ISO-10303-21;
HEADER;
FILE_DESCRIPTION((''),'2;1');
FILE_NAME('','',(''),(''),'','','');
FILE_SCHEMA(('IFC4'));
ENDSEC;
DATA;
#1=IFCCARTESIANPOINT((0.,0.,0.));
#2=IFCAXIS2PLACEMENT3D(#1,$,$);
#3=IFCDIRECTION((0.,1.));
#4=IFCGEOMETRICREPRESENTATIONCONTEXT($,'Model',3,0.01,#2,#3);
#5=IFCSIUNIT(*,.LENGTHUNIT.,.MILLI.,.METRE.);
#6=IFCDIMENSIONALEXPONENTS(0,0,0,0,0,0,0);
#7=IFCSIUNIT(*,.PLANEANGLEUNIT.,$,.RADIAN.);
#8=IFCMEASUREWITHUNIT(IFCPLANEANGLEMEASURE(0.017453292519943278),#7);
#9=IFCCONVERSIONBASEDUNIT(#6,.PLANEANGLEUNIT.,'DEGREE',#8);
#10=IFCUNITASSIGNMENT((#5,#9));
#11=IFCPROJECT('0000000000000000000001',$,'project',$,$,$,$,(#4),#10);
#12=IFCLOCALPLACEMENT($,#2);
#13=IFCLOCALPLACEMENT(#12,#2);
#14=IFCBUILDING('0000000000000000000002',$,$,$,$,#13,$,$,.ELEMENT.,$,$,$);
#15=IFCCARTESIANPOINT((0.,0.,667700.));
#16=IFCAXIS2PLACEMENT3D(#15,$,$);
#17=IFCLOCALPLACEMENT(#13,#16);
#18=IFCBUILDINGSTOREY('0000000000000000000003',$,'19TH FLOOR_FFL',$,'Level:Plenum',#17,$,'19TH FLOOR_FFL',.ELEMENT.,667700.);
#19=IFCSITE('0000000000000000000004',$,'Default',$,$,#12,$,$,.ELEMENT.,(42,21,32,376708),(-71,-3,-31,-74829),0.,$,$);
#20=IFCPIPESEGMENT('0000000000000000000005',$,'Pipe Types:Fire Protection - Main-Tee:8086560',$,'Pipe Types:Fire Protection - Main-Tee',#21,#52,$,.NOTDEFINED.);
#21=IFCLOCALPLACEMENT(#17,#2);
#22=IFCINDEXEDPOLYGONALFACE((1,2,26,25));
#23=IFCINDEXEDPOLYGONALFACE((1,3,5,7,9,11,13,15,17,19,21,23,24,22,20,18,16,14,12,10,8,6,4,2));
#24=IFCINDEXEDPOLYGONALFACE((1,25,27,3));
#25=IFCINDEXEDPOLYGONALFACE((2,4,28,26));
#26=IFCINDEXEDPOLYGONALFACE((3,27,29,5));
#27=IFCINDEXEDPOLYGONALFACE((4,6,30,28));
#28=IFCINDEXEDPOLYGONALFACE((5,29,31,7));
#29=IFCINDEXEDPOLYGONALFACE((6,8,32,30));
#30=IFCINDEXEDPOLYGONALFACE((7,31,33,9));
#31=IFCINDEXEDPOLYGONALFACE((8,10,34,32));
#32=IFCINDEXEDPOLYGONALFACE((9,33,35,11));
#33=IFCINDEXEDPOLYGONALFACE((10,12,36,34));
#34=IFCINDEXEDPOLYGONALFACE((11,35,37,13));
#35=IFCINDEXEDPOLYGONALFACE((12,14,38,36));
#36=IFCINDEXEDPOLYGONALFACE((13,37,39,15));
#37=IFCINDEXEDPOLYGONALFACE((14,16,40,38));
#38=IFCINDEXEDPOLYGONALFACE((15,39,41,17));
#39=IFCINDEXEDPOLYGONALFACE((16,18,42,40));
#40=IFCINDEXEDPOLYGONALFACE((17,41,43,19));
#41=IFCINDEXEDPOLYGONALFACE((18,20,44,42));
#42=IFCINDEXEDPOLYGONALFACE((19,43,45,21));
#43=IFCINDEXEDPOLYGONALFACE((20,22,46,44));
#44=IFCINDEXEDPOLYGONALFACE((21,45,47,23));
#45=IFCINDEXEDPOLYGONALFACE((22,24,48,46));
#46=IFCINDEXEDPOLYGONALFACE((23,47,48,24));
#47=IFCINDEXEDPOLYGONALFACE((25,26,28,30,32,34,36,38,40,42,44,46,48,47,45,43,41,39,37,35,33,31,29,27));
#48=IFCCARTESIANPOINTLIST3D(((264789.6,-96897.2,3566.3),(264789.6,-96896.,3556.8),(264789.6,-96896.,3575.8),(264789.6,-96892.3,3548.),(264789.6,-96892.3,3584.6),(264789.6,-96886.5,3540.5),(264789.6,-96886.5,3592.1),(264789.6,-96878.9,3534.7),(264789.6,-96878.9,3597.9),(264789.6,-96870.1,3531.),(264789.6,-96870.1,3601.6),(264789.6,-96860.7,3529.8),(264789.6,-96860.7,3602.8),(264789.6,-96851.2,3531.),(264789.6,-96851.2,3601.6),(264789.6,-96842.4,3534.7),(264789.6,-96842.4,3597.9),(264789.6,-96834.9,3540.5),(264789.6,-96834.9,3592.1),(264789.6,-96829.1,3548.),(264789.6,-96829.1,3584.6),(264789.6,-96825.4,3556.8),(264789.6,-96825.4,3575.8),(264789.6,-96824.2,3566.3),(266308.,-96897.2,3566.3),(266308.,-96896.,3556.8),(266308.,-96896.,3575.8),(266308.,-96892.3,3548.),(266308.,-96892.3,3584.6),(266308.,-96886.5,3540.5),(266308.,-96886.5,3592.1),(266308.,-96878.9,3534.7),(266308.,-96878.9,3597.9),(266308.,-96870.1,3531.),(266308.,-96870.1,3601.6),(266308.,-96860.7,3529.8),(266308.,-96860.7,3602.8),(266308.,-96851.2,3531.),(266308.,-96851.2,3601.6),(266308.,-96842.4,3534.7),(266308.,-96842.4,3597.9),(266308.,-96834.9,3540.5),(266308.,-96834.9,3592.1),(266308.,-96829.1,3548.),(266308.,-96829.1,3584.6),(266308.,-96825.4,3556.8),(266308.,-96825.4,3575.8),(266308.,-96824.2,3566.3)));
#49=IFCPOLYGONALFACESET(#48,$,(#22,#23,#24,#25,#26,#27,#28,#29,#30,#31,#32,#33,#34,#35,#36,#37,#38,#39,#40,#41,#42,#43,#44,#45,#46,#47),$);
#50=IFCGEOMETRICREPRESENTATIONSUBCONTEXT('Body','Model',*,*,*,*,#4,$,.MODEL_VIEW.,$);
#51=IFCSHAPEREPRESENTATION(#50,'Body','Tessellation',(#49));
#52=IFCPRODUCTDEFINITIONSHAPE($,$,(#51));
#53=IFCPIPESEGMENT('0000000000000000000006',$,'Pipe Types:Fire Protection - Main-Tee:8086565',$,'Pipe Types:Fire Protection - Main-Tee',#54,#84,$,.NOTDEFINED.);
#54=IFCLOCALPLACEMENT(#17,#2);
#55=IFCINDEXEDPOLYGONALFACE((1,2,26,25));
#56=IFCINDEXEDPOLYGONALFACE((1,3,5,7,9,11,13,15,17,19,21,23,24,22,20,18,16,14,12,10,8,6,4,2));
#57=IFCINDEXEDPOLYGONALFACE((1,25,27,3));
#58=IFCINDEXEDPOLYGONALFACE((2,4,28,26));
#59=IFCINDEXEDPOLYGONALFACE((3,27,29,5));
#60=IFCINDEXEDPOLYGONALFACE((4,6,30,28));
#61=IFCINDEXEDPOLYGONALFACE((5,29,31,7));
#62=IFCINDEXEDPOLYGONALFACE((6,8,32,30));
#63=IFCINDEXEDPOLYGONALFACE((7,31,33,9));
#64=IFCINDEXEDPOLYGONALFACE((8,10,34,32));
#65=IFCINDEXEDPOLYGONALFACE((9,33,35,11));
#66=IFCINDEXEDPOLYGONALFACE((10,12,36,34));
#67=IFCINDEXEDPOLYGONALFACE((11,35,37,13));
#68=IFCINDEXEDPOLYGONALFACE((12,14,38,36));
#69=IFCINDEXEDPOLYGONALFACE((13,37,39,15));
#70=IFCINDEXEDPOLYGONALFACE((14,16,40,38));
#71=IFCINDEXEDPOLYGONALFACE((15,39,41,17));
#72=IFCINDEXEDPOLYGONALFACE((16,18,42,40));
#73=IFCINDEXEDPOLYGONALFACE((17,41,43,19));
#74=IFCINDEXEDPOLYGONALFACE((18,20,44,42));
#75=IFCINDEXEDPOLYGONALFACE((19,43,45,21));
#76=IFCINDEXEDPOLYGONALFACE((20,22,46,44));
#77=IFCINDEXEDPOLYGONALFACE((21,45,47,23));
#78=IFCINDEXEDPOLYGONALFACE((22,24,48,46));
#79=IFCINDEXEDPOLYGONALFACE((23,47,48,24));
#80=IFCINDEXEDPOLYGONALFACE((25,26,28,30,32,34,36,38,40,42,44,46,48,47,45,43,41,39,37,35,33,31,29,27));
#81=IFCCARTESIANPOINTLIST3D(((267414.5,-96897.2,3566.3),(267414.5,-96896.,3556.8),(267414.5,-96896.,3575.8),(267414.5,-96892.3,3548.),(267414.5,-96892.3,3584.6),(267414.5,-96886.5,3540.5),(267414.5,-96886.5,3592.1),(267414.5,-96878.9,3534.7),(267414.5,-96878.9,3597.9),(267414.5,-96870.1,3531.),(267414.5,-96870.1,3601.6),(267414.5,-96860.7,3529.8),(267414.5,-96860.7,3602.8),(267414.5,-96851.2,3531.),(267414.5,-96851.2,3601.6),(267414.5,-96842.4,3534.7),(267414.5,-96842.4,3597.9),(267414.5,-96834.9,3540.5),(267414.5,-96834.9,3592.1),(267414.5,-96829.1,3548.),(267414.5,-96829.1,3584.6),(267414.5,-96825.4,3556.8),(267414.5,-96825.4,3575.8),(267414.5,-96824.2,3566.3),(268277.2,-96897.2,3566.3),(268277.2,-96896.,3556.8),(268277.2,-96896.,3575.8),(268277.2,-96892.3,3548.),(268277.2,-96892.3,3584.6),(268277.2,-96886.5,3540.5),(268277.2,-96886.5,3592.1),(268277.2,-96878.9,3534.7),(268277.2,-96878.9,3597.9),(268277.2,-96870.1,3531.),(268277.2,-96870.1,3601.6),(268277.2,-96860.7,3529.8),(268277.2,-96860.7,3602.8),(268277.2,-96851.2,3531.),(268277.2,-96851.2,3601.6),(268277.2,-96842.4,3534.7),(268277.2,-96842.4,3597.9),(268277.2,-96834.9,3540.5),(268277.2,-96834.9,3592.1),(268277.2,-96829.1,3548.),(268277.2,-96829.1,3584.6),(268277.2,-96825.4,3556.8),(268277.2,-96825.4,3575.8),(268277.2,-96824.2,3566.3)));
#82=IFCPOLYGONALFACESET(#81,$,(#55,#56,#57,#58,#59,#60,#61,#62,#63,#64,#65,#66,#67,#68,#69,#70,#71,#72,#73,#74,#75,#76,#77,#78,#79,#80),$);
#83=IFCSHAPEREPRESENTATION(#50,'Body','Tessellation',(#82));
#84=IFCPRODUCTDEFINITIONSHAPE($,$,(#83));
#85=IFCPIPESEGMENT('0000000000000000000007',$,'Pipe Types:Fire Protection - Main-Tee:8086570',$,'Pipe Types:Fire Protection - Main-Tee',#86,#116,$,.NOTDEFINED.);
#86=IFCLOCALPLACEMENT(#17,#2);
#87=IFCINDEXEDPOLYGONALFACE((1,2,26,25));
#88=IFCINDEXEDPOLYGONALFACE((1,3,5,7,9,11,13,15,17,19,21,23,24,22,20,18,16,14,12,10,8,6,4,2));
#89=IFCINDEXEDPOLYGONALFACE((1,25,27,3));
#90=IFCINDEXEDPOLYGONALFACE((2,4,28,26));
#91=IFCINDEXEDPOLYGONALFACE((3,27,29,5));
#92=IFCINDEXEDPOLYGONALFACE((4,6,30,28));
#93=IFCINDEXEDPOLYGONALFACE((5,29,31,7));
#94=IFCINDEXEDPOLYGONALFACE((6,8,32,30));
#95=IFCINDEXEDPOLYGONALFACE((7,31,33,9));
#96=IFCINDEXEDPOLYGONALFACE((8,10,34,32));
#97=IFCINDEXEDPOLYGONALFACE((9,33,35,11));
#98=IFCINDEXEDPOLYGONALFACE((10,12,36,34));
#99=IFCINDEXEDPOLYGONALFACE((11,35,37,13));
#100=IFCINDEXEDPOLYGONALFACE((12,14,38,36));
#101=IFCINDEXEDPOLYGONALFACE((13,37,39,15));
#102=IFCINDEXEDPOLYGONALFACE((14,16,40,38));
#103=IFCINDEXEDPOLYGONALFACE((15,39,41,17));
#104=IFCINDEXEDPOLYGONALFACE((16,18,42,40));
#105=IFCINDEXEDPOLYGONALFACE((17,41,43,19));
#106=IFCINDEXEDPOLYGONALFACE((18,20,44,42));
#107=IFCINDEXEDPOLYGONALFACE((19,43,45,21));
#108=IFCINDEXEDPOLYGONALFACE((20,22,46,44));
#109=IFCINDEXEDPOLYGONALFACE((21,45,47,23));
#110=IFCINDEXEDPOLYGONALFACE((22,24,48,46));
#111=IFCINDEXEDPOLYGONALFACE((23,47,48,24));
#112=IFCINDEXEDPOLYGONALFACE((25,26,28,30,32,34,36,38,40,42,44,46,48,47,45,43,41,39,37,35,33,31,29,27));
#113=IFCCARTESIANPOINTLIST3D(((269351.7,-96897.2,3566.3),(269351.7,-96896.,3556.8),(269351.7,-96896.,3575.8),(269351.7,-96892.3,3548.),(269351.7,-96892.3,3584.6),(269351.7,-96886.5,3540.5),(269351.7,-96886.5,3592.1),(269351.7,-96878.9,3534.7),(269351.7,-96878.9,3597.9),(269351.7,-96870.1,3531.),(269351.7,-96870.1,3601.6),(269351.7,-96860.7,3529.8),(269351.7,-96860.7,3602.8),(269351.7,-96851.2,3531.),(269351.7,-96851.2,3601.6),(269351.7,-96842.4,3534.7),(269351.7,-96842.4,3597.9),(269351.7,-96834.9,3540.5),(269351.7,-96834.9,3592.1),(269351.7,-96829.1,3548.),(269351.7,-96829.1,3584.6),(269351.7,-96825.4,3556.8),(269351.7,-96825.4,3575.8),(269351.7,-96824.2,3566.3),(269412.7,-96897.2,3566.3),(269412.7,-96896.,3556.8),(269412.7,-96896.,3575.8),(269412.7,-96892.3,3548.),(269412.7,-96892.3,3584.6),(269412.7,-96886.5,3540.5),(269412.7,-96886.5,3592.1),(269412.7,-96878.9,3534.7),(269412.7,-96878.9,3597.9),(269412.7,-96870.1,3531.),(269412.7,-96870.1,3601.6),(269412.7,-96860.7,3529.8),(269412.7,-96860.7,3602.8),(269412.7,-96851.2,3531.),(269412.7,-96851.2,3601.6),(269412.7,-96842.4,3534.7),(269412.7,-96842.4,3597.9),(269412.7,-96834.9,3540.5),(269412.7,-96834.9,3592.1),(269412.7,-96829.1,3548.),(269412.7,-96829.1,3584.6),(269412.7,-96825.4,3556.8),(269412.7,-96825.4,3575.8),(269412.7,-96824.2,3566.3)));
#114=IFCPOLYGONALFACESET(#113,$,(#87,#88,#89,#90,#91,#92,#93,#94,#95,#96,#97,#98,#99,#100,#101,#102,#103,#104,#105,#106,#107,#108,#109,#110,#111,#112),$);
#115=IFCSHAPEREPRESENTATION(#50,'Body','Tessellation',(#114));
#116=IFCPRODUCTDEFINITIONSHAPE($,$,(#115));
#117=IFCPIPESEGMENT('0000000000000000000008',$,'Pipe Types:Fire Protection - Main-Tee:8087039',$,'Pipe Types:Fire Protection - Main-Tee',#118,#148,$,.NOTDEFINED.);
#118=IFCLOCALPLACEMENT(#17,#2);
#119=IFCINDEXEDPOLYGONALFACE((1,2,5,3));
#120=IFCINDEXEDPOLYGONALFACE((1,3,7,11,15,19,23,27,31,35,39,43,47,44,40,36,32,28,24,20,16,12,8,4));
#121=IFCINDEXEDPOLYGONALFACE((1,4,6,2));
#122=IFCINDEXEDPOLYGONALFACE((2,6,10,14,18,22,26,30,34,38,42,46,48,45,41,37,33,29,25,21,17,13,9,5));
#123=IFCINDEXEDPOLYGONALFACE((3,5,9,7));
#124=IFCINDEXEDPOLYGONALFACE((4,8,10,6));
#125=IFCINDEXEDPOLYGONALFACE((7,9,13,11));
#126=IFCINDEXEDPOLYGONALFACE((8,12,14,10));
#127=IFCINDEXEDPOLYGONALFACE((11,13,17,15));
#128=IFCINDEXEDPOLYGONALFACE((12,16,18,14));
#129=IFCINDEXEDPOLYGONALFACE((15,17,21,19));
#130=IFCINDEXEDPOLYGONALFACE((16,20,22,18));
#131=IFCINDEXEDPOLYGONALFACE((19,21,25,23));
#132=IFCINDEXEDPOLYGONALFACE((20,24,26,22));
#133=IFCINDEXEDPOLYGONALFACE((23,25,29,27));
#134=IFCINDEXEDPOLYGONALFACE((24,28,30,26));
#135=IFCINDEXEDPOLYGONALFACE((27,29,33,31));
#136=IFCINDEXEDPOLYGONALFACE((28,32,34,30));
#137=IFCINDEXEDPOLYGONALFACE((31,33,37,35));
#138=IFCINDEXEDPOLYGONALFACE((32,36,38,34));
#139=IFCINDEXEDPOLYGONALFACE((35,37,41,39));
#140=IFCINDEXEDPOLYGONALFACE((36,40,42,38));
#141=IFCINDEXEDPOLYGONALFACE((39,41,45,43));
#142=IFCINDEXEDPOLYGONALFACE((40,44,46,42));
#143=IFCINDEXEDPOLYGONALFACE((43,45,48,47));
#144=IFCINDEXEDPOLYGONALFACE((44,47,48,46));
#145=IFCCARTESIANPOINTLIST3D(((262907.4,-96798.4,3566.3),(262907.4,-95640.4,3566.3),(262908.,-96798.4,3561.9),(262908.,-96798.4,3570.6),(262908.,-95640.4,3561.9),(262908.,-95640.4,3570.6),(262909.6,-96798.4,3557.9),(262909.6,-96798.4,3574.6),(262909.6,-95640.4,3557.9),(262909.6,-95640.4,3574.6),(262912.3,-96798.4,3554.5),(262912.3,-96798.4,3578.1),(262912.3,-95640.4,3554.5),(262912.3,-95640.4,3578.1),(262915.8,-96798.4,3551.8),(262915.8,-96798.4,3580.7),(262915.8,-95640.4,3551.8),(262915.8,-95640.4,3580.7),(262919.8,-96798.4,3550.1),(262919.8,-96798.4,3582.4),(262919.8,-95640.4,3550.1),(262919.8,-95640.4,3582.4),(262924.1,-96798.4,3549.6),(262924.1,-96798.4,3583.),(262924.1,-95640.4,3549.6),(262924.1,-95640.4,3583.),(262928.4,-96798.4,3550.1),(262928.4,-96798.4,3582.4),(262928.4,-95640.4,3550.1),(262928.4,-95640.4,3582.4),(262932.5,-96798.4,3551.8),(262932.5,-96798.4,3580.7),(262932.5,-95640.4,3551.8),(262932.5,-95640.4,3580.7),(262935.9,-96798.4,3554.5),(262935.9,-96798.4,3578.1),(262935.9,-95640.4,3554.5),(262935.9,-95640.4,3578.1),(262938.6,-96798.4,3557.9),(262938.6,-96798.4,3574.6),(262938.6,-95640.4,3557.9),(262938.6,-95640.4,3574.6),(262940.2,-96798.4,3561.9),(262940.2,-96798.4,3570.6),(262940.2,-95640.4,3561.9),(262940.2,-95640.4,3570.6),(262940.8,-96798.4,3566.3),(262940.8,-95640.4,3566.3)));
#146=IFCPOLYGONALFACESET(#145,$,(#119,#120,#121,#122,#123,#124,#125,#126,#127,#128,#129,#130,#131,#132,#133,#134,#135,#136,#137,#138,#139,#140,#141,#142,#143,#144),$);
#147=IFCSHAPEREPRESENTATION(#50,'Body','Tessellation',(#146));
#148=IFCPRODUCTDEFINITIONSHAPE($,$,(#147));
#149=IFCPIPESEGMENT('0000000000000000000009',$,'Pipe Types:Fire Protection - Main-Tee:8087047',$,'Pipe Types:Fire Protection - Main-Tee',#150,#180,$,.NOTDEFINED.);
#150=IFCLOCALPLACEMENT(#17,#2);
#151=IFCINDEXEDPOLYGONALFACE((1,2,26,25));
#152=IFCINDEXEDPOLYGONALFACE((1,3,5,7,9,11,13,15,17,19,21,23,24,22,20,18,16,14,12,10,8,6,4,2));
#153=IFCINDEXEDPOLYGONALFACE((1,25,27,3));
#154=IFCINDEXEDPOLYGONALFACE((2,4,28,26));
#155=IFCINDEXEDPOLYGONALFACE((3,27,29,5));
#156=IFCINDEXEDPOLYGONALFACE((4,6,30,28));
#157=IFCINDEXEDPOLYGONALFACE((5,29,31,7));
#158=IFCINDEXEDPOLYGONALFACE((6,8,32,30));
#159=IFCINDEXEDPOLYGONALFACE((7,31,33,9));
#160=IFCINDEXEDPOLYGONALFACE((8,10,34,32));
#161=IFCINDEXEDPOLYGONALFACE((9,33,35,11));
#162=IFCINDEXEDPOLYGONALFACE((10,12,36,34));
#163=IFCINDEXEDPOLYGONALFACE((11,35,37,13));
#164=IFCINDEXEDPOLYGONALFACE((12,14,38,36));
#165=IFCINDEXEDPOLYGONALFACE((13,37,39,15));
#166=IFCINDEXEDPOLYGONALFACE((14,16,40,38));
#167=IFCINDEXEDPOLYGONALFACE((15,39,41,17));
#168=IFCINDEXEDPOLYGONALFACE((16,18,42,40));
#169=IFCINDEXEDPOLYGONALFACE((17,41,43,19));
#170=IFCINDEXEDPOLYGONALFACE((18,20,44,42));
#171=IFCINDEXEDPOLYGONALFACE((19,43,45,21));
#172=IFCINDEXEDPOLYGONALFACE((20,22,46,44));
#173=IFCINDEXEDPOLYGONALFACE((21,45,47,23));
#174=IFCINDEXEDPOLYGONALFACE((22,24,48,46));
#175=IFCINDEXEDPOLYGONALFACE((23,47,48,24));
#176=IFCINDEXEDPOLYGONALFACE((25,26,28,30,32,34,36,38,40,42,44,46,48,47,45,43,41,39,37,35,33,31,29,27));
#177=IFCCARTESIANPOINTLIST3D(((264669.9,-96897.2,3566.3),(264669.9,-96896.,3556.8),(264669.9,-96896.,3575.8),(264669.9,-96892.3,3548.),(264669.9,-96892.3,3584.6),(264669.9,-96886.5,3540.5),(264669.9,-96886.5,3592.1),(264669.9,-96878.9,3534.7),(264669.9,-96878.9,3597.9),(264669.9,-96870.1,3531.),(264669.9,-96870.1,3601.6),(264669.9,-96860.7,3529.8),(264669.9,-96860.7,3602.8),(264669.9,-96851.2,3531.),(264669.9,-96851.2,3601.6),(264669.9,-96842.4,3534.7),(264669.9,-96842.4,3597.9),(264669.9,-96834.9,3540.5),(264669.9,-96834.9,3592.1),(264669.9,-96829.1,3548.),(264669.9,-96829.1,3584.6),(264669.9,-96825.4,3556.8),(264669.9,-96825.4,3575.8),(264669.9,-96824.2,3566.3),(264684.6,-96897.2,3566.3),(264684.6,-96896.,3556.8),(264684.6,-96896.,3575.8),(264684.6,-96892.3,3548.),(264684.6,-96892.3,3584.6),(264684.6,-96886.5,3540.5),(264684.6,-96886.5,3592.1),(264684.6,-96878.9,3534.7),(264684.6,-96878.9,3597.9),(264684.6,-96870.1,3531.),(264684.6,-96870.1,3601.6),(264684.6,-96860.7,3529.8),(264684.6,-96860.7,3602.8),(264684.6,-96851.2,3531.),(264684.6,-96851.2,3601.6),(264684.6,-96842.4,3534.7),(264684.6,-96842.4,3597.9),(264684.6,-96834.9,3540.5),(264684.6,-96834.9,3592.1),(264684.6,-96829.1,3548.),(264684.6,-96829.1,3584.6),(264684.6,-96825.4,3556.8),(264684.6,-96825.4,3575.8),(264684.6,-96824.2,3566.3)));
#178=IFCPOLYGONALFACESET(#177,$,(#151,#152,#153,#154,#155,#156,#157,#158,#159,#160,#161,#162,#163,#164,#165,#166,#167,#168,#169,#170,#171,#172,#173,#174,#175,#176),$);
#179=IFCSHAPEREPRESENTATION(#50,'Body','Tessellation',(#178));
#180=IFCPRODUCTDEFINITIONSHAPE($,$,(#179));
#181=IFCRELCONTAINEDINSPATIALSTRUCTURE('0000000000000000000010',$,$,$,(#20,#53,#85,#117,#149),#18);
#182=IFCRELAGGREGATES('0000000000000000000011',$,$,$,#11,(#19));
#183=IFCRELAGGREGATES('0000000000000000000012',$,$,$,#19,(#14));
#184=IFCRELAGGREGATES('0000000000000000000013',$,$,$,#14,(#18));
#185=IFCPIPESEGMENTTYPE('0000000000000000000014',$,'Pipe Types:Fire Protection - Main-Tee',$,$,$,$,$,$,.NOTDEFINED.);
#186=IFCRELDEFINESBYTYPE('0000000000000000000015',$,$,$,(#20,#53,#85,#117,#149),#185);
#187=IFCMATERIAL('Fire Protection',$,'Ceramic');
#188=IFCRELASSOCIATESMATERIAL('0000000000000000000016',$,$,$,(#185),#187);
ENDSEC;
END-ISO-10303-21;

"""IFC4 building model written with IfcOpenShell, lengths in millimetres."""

from ifc_helpers import new_model, entity, si_unit, converted_unit, direction, frame, origin, place, context, subcontext, project, spatial, arc, indexed_curve, outline, extrude, material, type_object, element, save


model = new_model("IFC4")

# Units and contexts
model_context = context("Model", 3, precision=0.01, world=origin(), true_north=direction((0.0, 1.0)))
body_context = subcontext(model_context, "Body", "Model", "MODEL_VIEW")
ifc_project = project(units=[si_unit("LENGTHUNIT", "METRE", prefix="MILLI"), converted_unit("PLANEANGLEUNIT", "DEGREE", entity("IfcPlaneAngleMeasure", 0.017453292519943278), si_unit("PLANEANGLEUNIT", "RADIAN"), dimensions=[0, 0, 0, 0, 0, 0, 0])], contexts=[model_context])

# Site, building, storey
site_placement = place(None, origin())
site = spatial("IfcSite", under=ifc_project, at=site_placement, Name="Default", CompositionType="ELEMENT", RefLatitude=(42, 21, 32, 376708), RefLongitude=(-71, -3, -31, -74829), RefElevation=0.0)
building_placement = place(site_placement, origin())
building = spatial("IfcBuilding", under=site, at=building_placement, CompositionType="ELEMENT")
storey_placement = place(building_placement, frame((0.0, 0.0, 667700.0)))
storey = spatial("IfcBuildingStorey", under=building, at=storey_placement, Name="19TH FLOOR_FFL", ObjectType="Level:Plenum", LongName="19TH FLOOR_FFL", CompositionType="ELEMENT", Elevation=667700.0)

# Pipe segments
ifc_material = material(Name="Fire Protection", Category="Ceramic")
pipe_segment_type = type_object("IfcPipeSegmentType", Name="Pipe Types:Fire Protection - Main-Tee", PredefinedType="NOTDEFINED", material=ifc_material)
pipe_segment_1_placement = place(storey_placement, origin())
element("IfcPipeSegment", 1, at=pipe_segment_1_placement, inside=storey, type_object=pipe_segment_type, Name="Pipe Types:Fire Protection - Main-Tee:8086560", ObjectType="Pipe Types:Fire Protection - Main-Tee", PredefinedType="NOTDEFINED", context=body_context, shape_type="SweptSolid", body=[
    extrude(outline(indexed_curve([(36.5, 0.0), (25.8, 25.8), (0.0, 36.5), (-25.8, 25.8), (-36.5, 0.0), (-25.8, -25.8), (0.0, -36.5), (25.8, -25.8)], segments=[arc(1, 2, 3), arc(3, 4, 5), arc(5, 6, 7), arc(7, 8, 1)], self_intersect=False)), frame((264789.6, -96860.7, 3566.3), z_axis=(1.0, 0.0, 0.0), x_axis=(0.0, 1.0, 0.0)), (0.0, 0.0, 1.0), 1518.4),
])
pipe_segment_2_placement = place(storey_placement, origin())
element("IfcPipeSegment", 2, at=pipe_segment_2_placement, inside=storey, type_object=pipe_segment_type, Name="Pipe Types:Fire Protection - Main-Tee:8086565", ObjectType="Pipe Types:Fire Protection - Main-Tee", PredefinedType="NOTDEFINED", context=body_context, shape_type="SweptSolid", body=[
    extrude(outline(indexed_curve([(36.5, 0.0), (25.8, 25.8), (0.0, 36.5), (-25.8, 25.8), (-36.5, 0.0), (-25.8, -25.8), (0.0, -36.5), (25.8, -25.8)], segments=[arc(1, 2, 3), arc(3, 4, 5), arc(5, 6, 7), arc(7, 8, 1)], self_intersect=False)), frame((267414.5, -96860.7, 3566.3), z_axis=(1.0, 0.0, 0.0), x_axis=(0.0, -1.0, 0.0)), (0.0, 0.0, 1.0), 862.7),
])
pipe_segment_3_placement = place(storey_placement, origin())
element("IfcPipeSegment", 3, at=pipe_segment_3_placement, inside=storey, type_object=pipe_segment_type, Name="Pipe Types:Fire Protection - Main-Tee:8086570", ObjectType="Pipe Types:Fire Protection - Main-Tee", PredefinedType="NOTDEFINED", context=body_context, shape_type="SweptSolid", body=[
    extrude(outline(indexed_curve([(36.5, 0.0), (25.8, 25.8), (0.0, 36.5), (-25.8, 25.8), (-36.5, 0.0), (-25.8, -25.8), (0.0, -36.5), (25.8, -25.8)], segments=[arc(1, 2, 3), arc(3, 4, 5), arc(5, 6, 7), arc(7, 8, 1)], self_intersect=False)), frame((269351.7, -96860.7, 3566.3), z_axis=(1.0, 0.0, 0.0), x_axis=(0.0, -1.0, 0.0)), (0.0, 0.0, 1.0), 61.0),
])
pipe_segment_4_placement = place(storey_placement, origin())
element("IfcPipeSegment", 4, at=pipe_segment_4_placement, inside=storey, type_object=pipe_segment_type, Name="Pipe Types:Fire Protection - Main-Tee:8087039", ObjectType="Pipe Types:Fire Protection - Main-Tee", PredefinedType="NOTDEFINED", context=body_context, shape_type="SweptSolid", body=[
    extrude(outline(indexed_curve([(16.7, 0.0), (11.8, 11.8), (0.0, 16.7), (-11.8, 11.8), (-16.7, 0.0), (-11.8, -11.8), (0.0, -16.7), (11.8, -11.8)], segments=[arc(1, 2, 3), arc(3, 4, 5), arc(5, 6, 7), arc(7, 8, 1)], self_intersect=False)), frame((262924.1, -96798.4, 3566.3), z_axis=(0.0, 1.0, 0.0), x_axis=(1.0, 0.0, 0.0)), (0.0, 0.0, 1.0), 1158.0),
])
pipe_segment_5_placement = place(storey_placement, origin())
element("IfcPipeSegment", 5, at=pipe_segment_5_placement, inside=storey, type_object=pipe_segment_type, Name="Pipe Types:Fire Protection - Main-Tee:8087047", ObjectType="Pipe Types:Fire Protection - Main-Tee", PredefinedType="NOTDEFINED", context=body_context, shape_type="SweptSolid", body=[
    extrude(outline(indexed_curve([(36.5, 0.0), (25.8, 25.8), (0.0, 36.5), (-25.8, 25.8), (-36.5, 0.0), (-25.8, -25.8), (0.0, -36.5), (25.8, -25.8)], segments=[arc(1, 2, 3), arc(3, 4, 5), arc(5, 6, 7), arc(7, 8, 1)], self_intersect=False)), frame((264669.9, -96860.7, 3566.3), z_axis=(1.0, 0.0, 0.0), x_axis=(0.0, 1.0, 0.0)), (0.0, 0.0, 1.0), 14.7),
])

save(model, "model.ifc")
